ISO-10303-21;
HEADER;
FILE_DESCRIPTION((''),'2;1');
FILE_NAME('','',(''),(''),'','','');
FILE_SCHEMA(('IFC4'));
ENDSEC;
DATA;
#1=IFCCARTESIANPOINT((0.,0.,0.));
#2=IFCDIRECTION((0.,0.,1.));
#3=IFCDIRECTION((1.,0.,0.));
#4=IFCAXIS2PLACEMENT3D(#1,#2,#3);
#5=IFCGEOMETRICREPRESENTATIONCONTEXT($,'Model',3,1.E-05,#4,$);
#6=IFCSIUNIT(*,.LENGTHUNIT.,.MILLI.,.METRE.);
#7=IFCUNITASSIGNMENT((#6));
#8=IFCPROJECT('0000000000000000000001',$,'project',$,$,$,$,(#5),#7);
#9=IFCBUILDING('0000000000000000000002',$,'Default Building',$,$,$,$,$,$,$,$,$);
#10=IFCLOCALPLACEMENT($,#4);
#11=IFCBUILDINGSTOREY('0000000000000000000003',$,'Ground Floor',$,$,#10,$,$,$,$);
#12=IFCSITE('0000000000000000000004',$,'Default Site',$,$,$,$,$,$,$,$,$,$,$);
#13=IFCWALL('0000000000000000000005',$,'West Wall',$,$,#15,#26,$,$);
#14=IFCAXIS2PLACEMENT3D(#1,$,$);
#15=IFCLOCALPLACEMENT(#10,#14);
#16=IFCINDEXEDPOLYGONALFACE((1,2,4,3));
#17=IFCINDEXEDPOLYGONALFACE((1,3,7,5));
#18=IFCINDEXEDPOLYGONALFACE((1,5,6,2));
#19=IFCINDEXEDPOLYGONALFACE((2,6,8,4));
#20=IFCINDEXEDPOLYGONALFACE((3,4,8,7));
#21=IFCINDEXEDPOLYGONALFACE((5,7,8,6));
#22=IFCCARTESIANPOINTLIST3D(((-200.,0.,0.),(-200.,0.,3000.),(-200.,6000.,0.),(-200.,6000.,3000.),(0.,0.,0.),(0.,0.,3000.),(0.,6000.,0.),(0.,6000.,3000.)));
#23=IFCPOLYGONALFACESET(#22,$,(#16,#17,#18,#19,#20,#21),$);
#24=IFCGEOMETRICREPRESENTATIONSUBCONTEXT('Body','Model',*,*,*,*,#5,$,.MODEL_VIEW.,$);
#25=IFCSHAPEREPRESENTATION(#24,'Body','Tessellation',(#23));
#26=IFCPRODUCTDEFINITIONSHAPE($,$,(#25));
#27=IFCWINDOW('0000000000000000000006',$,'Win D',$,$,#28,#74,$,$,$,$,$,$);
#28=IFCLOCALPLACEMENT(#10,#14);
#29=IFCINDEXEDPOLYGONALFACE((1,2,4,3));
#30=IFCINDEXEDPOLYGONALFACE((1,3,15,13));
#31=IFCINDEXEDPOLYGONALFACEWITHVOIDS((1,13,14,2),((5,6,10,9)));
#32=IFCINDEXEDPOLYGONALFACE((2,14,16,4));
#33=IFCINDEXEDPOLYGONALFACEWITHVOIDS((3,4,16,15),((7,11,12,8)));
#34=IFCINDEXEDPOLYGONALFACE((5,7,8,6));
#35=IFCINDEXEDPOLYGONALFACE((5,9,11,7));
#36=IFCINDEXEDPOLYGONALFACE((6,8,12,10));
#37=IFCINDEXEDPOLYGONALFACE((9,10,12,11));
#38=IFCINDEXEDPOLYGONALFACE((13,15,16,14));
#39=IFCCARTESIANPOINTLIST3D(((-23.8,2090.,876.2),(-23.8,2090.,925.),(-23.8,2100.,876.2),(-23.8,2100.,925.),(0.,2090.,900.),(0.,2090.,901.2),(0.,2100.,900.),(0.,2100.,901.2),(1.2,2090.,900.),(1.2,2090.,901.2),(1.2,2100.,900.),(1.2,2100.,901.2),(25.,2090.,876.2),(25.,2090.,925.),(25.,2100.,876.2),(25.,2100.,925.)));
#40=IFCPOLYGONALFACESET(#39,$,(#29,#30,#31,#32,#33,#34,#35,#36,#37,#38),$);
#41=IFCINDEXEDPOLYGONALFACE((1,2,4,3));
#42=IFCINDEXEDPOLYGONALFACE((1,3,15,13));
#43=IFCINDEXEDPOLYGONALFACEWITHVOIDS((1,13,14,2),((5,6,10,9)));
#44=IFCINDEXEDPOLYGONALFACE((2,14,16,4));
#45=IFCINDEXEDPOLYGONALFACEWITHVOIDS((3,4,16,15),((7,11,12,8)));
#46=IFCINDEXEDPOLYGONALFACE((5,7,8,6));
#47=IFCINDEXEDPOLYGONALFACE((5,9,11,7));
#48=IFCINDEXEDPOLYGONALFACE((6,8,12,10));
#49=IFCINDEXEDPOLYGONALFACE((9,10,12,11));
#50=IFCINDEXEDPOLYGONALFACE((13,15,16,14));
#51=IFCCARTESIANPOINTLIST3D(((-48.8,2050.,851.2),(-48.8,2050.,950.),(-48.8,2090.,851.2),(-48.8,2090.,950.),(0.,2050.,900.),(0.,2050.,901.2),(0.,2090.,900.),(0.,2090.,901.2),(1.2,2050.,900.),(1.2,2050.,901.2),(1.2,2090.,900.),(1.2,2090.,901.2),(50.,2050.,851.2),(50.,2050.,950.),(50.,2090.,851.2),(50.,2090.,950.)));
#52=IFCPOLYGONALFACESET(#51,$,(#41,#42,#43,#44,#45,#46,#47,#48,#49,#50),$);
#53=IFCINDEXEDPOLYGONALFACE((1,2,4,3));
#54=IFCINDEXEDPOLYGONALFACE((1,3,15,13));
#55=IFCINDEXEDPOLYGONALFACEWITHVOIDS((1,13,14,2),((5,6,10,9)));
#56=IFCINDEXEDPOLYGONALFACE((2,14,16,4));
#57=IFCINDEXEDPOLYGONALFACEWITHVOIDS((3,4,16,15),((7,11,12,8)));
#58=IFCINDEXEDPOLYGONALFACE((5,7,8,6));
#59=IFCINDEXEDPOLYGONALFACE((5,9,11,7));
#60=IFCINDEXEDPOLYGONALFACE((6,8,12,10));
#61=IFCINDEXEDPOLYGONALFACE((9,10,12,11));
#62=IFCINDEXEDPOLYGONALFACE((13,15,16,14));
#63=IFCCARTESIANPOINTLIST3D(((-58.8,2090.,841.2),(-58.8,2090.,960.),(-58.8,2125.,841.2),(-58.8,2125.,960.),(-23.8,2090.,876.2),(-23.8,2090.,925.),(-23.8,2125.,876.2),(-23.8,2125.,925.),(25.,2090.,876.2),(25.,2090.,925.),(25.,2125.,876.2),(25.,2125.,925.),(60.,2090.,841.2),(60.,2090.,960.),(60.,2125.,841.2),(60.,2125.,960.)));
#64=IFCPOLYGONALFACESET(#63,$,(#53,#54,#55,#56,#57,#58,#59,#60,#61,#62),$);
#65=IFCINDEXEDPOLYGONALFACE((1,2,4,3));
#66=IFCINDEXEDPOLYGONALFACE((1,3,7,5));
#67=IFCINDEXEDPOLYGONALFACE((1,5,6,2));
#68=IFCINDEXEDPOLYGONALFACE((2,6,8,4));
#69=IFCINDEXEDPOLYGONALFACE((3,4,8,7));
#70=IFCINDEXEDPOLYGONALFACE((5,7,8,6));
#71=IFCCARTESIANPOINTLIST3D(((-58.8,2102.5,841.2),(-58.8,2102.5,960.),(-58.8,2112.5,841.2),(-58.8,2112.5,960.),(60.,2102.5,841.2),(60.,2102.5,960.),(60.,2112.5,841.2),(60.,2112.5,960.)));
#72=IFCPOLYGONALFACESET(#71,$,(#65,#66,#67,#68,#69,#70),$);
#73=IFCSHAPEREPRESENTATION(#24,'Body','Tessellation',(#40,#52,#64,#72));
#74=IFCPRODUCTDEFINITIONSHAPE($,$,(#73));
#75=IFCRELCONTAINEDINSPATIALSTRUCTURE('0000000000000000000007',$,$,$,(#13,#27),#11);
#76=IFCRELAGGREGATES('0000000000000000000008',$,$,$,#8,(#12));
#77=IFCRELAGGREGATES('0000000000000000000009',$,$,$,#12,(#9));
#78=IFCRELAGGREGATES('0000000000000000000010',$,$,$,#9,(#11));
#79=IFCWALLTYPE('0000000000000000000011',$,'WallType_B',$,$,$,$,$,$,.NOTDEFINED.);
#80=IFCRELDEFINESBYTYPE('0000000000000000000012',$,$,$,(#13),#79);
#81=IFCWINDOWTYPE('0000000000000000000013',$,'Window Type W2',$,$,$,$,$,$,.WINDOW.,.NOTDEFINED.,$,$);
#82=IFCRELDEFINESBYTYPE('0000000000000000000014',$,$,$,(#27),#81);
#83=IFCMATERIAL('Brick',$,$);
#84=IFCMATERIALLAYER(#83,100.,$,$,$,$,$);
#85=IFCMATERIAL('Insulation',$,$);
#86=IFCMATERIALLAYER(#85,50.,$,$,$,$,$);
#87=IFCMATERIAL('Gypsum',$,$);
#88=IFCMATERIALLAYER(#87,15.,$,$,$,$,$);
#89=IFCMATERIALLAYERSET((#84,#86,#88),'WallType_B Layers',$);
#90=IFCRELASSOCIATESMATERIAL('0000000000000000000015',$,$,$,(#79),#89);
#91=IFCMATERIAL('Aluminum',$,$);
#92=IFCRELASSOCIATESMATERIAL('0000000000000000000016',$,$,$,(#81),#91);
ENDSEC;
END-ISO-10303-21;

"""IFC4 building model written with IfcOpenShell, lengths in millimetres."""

from ifc_helpers import new_model, si_unit, frame, origin_with_axes, place, context, subcontext, project, spatial, line, indexed_curve, outline, extrude, material, layer, layer_set, type_object, element, fill, save


model = new_model("IFC4")

# Units and contexts
model_context = context("Model", 3, precision=1e-05, world=origin_with_axes())
body_context = subcontext(model_context, "Body", "Model", "MODEL_VIEW")
ifc_project = project(units=[si_unit("LENGTHUNIT", "METRE", prefix="MILLI")], contexts=[model_context])

# Site, building, storey
site = spatial("IfcSite", under=ifc_project, Name="Default Site")
building = spatial("IfcBuilding", under=site, Name="Default Building")
storey_placement = place(None, origin_with_axes())
storey = spatial("IfcBuildingStorey", under=building, at=storey_placement, Name="Ground Floor")

# Shared definitions
ifc_material_1 = material(Name="Brick")
ifc_layer_1 = layer(ifc_material_1, 100.0)
ifc_material_2 = material(Name="Insulation")
ifc_layer_2 = layer(ifc_material_2, 50.0)
ifc_material_3 = material(Name="Gypsum")
ifc_layer_3 = layer(ifc_material_3, 15.0)
ifc_layer_set_1 = layer_set([ifc_layer_1, ifc_layer_2, ifc_layer_3], Name="WallType_B Layers")
wall_type_1 = type_object("IfcWallType", Name="WallType_B", PredefinedType="NOTDEFINED", material=ifc_layer_set_1)
ifc_material_4 = material(Name="Aluminum")
window_type_1 = type_object("IfcWindowType", Name="Window Type W2", PartitioningType="NOTDEFINED", PredefinedType="WINDOW", material=ifc_material_4)

# Wall, opening, window
wall_1_placement = place(storey_placement, origin_with_axes())
wall_1 = element("IfcWall", 1, at=wall_1_placement, inside=storey, type_object=wall_type_1, Name="West Wall", context=body_context, shape_type="SweptSolid", body=[
    extrude(outline(indexed_curve([(0.0, 0.0), (0.0, 6000.0), (-200.0, 6000.0), (-200.0, 0.0), (0.0, 0.0)])), None, (0.0, 0.0, 1.0), 3000.0),
])
opening_1_placement = place(wall_1_placement, frame((0.0, 0.0, 900.0), z_axis=(0.0, 0.0, 1.0), x_axis=(1.0, 0.0, 0.0)))
opening_1 = element("IfcOpeningElement", 2, at=opening_1_placement, cuts=wall_1, context=body_context, shape_type="SweptSolid", body=[
    extrude(outline(indexed_curve([(0.0, 2000.0), (1200.0, 2000.0), (1200.0, 2200.0), (0.0, 2200.0), (0.0, 2000.0)])), None, (0.0, 0.0, 1.0), 1200.0),
])
window_1_placement = place(storey_placement, frame((0.0, 2000.0, 900.0), z_axis=(0.0, 0.0, 1.0), x_axis=(1.0, 0.0, 0.0)))
window_1 = element("IfcWindow", 3, at=window_1_placement, inside=storey, type_object=window_type_1, Name="Win D", context=body_context, shape_type="SweptSolid", body=[
    extrude(outline(indexed_curve([(0.0, 0.0), (1.2, 0.0), (1.2, 1.2), (0.0, 1.2)], segments=[line(1, 2, 3, 4, 1)]), holes=[indexed_curve([(25.0, 25.0), (-23.8, 25.0), (-23.8, -23.8), (25.0, -23.8)], segments=[line(1, 2, 3, 4, 1)])]), frame((0.0, 90.0, 0.0), z_axis=(0.0, -1.0, 0.0), x_axis=(1.0, 0.0, 0.0)), (0.0, 0.0, -1.0), 10.0),
    extrude(outline(indexed_curve([(0.0, 0.0), (1.2, 0.0), (1.2, 1.2), (0.0, 1.2)], segments=[line(1, 2, 3, 4, 1)]), holes=[indexed_curve([(50.0, 50.0), (-48.8, 50.0), (-48.8, -48.8), (50.0, -48.8)], segments=[line(1, 2, 3, 4, 1)])]), frame((0.0, 50.0, 0.0), z_axis=(0.0, -1.0, 0.0), x_axis=(1.0, 0.0, 0.0)), (0.0, 0.0, -1.0), 40.0),
    extrude(outline(indexed_curve([(0.0, 0.0), (-48.8, 0.0), (-48.8, -48.8), (0.0, -48.8)], segments=[line(1, 2, 3, 4, 1)]), holes=[indexed_curve([(35.0, 35.0), (-83.8, 35.0), (-83.8, -83.8), (35.0, -83.8)], segments=[line(1, 2, 3, 4, 1)])]), frame((25.0, 90.0, 25.0), z_axis=(0.0, -1.0, 0.0), x_axis=(1.0, 0.0, 0.0)), (0.0, 0.0, -1.0), 35.0),
    extrude(outline(indexed_curve([(35.0, 35.0), (-83.8, 35.0), (-83.8, -83.8), (35.0, -83.8)], segments=[line(1, 2, 3, 4, 1)])), frame((25.0, 102.5, 25.0), z_axis=(0.0, -1.0, 0.0), x_axis=(1.0, 0.0, 0.0)), (0.0, 0.0, -1.0), 10.0),
])
fill(opening_1, window_1)

save(model, "model.ifc")
